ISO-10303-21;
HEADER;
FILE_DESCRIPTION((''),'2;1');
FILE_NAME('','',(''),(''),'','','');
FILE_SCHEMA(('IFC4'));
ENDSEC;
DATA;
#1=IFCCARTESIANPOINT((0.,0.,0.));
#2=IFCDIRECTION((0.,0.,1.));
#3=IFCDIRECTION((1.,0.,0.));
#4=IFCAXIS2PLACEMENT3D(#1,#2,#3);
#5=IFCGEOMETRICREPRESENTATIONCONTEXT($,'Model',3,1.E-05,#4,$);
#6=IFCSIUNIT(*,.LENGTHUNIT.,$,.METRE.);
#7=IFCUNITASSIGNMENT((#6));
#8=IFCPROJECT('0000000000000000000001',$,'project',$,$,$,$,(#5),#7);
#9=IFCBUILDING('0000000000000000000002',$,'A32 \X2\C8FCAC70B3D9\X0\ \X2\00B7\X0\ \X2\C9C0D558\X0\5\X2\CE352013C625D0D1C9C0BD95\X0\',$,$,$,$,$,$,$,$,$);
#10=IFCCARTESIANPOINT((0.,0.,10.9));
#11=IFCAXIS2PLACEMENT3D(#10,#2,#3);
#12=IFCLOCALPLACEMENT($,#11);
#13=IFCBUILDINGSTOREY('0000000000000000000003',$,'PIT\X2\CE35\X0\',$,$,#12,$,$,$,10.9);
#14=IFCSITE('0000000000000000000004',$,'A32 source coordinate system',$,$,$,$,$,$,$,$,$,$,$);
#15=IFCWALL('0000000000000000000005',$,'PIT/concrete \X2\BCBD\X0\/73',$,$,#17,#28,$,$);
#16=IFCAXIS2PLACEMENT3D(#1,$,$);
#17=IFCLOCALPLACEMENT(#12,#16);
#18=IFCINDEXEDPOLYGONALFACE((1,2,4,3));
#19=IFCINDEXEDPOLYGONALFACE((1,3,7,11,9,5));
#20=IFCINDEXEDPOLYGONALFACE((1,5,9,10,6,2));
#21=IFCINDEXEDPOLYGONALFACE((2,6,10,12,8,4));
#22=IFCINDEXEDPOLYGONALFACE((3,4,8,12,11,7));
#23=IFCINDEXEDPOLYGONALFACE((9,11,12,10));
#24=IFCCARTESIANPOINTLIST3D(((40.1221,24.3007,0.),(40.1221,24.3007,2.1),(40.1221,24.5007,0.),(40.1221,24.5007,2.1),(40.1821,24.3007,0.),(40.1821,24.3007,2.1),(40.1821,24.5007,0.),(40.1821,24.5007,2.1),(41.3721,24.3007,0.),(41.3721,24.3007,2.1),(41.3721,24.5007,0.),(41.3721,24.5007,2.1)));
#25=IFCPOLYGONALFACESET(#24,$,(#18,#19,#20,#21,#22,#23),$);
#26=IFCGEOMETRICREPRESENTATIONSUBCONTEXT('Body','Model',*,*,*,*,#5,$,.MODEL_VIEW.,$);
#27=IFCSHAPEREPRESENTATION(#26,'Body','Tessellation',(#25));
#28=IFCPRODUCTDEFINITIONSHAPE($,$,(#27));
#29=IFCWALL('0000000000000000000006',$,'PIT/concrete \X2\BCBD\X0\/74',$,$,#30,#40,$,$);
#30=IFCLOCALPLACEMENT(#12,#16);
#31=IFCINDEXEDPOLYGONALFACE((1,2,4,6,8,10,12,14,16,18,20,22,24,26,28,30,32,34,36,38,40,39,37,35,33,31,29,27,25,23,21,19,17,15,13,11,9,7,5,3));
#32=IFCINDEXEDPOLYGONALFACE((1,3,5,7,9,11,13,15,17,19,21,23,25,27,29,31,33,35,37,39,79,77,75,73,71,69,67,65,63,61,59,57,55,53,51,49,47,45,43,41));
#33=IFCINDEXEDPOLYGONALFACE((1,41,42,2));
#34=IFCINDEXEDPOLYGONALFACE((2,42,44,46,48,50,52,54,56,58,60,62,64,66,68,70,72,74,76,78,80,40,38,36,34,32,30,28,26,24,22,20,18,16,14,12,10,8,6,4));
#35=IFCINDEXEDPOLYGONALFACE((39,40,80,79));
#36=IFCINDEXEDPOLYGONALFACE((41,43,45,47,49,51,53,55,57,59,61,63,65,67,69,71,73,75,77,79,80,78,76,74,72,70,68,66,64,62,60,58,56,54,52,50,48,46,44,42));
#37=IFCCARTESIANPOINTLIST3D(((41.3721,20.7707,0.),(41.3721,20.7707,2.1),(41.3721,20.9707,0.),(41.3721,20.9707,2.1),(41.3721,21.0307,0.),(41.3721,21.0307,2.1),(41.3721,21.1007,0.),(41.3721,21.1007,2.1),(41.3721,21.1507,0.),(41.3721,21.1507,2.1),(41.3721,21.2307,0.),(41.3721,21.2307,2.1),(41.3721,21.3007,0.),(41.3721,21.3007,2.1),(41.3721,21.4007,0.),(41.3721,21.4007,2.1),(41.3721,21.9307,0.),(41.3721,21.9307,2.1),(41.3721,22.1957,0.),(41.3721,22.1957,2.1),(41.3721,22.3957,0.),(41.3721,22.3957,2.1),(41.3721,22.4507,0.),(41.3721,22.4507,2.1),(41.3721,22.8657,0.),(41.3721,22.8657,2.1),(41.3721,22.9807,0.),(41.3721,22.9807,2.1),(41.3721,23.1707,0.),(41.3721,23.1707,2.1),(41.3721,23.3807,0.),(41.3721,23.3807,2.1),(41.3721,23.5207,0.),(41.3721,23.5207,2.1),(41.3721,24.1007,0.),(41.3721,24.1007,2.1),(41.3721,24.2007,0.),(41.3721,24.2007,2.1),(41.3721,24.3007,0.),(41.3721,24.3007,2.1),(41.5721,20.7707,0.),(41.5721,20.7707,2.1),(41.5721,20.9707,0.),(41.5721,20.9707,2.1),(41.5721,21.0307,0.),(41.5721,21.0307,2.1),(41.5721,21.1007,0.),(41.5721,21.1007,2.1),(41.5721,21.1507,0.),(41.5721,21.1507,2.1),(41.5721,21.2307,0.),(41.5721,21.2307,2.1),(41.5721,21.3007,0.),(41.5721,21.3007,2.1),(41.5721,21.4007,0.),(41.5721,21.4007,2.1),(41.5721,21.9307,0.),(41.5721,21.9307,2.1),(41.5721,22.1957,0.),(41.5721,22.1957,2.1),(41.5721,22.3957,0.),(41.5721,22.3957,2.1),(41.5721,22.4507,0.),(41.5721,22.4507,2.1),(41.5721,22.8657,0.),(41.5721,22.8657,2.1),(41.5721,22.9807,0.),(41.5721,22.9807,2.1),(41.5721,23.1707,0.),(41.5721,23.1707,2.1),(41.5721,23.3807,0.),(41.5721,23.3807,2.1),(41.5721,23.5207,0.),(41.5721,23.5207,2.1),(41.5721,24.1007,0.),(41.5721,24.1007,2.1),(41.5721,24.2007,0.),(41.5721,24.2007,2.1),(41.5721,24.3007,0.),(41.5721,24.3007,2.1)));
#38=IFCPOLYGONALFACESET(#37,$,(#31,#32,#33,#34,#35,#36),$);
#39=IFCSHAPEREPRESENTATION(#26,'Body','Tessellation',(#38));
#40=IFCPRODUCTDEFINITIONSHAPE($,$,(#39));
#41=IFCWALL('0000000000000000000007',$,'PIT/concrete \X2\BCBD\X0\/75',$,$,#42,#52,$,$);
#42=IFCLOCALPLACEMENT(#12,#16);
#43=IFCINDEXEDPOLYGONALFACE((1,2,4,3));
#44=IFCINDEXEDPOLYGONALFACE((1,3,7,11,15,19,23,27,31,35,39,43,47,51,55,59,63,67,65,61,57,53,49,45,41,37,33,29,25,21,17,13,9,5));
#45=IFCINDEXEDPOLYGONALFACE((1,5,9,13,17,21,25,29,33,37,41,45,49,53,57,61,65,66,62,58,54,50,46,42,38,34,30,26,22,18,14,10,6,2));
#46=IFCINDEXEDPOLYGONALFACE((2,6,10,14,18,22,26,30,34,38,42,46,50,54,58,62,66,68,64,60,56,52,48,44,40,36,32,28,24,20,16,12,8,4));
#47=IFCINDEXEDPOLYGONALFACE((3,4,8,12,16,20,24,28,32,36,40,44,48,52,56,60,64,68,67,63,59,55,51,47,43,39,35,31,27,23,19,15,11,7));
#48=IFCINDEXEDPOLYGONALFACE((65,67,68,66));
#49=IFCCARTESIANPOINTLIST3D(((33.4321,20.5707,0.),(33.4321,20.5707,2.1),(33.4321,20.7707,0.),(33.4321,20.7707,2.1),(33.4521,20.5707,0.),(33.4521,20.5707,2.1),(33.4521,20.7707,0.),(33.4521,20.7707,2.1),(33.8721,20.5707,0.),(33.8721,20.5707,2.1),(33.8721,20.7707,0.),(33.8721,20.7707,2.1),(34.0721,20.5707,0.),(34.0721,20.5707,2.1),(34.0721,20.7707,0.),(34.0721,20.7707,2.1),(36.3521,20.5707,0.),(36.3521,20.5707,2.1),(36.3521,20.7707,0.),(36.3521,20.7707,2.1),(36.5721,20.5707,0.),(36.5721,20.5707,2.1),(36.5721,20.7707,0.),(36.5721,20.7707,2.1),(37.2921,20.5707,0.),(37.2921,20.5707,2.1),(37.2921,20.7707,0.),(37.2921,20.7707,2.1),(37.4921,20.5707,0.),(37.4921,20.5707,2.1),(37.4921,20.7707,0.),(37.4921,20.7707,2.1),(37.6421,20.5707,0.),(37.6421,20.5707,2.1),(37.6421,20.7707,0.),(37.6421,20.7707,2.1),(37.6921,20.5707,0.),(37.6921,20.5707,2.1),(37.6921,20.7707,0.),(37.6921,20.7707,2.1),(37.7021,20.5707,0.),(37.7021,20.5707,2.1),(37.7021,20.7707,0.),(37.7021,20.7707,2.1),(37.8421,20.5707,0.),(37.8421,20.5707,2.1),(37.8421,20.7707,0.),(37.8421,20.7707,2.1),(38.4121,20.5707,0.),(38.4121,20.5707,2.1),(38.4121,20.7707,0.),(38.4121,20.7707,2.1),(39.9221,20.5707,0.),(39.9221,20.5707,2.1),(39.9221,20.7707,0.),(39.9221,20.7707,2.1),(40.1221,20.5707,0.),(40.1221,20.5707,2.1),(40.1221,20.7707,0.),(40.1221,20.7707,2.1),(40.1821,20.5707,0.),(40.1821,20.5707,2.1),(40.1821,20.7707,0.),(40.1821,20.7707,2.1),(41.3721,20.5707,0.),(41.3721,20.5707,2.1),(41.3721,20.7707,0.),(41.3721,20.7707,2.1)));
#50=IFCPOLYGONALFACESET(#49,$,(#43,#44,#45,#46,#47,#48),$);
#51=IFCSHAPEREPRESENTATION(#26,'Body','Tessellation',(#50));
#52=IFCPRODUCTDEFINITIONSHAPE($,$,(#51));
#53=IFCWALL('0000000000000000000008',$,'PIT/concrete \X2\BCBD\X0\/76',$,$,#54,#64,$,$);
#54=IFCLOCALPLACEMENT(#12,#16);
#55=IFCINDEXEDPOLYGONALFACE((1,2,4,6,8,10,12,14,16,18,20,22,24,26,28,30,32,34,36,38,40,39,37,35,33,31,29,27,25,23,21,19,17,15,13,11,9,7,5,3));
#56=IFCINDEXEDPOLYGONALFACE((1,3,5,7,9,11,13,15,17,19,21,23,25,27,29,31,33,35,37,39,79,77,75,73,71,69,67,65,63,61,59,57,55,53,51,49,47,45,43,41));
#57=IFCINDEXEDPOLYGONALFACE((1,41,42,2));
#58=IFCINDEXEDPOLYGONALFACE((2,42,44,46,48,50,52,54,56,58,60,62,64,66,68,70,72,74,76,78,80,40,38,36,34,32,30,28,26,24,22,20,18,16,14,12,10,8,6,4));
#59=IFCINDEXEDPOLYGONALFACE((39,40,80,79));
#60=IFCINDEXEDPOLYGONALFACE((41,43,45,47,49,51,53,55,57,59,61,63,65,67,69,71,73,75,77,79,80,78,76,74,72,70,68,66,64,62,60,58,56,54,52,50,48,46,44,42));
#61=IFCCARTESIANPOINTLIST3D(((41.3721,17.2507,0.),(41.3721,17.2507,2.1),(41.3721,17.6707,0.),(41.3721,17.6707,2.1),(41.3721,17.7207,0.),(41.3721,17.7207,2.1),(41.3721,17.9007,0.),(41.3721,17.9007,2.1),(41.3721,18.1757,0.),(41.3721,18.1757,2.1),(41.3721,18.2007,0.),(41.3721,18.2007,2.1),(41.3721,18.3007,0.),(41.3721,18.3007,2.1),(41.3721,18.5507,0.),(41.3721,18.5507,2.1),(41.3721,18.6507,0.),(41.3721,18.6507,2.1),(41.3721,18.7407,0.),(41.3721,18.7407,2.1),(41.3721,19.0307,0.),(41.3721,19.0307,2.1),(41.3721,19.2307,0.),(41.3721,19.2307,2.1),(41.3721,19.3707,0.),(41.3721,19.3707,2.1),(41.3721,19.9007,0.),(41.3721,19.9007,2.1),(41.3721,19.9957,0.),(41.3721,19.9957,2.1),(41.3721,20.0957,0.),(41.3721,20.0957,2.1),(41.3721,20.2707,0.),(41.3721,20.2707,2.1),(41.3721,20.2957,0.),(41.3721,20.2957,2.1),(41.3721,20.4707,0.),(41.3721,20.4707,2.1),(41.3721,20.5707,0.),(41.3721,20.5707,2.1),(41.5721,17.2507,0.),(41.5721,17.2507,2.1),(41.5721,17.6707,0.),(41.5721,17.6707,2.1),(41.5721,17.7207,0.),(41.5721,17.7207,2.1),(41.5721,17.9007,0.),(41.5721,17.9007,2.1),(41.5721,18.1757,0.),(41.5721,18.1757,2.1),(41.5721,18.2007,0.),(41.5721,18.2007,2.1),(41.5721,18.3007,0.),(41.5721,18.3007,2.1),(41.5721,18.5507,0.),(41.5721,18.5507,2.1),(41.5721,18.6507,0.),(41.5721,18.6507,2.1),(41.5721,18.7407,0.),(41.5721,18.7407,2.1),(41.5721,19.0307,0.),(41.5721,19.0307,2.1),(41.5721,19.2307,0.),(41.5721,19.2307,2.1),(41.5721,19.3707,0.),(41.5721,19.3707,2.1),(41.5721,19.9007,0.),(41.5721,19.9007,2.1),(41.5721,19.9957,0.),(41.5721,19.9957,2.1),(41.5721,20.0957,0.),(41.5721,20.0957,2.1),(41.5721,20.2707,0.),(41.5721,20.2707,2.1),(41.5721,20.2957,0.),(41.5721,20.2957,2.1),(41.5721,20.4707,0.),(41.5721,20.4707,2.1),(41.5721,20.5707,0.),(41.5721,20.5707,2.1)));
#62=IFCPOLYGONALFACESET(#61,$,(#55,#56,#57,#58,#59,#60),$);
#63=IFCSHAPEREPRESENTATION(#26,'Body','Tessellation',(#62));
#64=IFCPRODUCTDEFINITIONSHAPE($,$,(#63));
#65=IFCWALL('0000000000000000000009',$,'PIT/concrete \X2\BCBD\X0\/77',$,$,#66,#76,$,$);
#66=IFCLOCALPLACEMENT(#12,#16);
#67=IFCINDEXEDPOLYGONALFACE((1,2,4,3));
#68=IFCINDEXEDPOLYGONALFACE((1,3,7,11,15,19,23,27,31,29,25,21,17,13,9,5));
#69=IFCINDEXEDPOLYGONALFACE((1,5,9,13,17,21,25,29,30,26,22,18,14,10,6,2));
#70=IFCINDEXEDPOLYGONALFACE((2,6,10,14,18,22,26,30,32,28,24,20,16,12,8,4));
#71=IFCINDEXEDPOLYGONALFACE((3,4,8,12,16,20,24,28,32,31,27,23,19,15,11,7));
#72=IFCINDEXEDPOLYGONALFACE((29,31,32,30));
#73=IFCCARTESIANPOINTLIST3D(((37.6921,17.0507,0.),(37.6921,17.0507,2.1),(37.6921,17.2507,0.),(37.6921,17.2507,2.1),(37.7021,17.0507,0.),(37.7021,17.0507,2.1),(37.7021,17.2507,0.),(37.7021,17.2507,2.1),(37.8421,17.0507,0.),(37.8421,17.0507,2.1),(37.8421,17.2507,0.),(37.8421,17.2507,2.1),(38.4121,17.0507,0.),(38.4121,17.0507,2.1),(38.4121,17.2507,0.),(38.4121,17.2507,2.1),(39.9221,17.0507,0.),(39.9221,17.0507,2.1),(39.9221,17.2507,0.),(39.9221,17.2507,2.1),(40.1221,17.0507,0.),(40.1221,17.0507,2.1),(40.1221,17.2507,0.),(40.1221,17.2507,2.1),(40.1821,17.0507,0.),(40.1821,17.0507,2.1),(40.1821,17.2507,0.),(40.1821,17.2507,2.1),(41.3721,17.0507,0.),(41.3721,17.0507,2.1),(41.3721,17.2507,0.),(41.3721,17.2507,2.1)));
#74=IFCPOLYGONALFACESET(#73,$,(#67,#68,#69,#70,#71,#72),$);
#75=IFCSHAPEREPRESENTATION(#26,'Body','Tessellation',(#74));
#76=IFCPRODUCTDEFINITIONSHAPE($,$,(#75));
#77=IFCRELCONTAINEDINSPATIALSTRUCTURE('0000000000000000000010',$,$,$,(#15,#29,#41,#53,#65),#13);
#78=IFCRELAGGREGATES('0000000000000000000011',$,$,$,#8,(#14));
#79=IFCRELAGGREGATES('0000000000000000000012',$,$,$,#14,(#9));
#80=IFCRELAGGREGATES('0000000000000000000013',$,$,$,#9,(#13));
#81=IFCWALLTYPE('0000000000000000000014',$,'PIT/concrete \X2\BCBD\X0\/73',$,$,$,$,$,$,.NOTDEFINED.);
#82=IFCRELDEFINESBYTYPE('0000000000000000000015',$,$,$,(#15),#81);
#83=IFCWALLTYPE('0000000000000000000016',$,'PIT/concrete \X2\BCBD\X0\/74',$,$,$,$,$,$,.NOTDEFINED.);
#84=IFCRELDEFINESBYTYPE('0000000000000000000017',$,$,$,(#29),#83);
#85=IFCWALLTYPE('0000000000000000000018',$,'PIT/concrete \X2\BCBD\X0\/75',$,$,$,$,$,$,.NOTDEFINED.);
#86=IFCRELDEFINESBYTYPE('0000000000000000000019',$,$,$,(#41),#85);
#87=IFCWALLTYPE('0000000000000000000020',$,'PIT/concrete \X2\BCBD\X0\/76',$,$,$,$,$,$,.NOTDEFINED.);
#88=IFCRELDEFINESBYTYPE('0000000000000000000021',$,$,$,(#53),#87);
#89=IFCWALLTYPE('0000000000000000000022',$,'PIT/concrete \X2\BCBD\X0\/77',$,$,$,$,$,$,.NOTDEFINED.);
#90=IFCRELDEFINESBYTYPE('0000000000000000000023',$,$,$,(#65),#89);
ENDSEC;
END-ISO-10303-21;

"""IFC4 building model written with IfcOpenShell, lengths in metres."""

from ifc_helpers import new_model, si_unit, frame, origin, origin_with_axes, place, context, subcontext, project, spatial, polyline, outline, extrude, source, transform, mapped, type_object, type_shapes, element, save


model = new_model("IFC4")

# Units and contexts
model_context = context("Model", 3, precision=1e-05, world=origin_with_axes())
body_context = subcontext(model_context, "Body", "Model", "MODEL_VIEW")
ifc_project = project(units=[si_unit("LENGTHUNIT", "METRE")], contexts=[model_context])

# Site, building, storey
site = spatial("IfcSite", under=ifc_project, Name="A32 source coordinate system")
building = spatial("IfcBuilding", under=site, Name="A32 주거동 · 지하5층–옥탑지붕")
storey_placement = place(None, frame((0.0, 0.0, 10.9), z_axis=(0.0, 0.0, 1.0), x_axis=(1.0, 0.0, 0.0)))
storey = spatial("IfcBuildingStorey", under=building, at=storey_placement, Name="PIT층", Elevation=10.9)

# Walls
wall_type_1 = type_object("IfcWallType", Name="PIT/concrete 벽/73", PredefinedType="NOTDEFINED")
shared_shape_1 = source(origin(), body_context, "Body", "SweptSolid", [
    extrude(outline(polyline([(40.1221, 24.3007), (40.1221, 24.5007), (40.1821, 24.5007), (41.3721, 24.5007), (41.3721, 24.3007), (40.1821, 24.3007), (40.1221, 24.3007)])), origin(), (0.0, 0.0, 1.0), 2.1),
])
type_shapes(wall_type_1, [shared_shape_1])
wall_1_placement = place(storey_placement, origin_with_axes())
element("IfcWall", 1, at=wall_1_placement, inside=storey, type_object=wall_type_1, Name="PIT/concrete 벽/73", context=body_context, shape_type="MappedRepresentation", body=[
    mapped(shared_shape_1, transform((0.0, 0.0, 0.0), scale=1.0)),
])
wall_type_2 = type_object("IfcWallType", Name="PIT/concrete 벽/74", PredefinedType="NOTDEFINED")
shared_shape_2 = source(origin(), body_context, "Body", "SweptSolid", [
    extrude(outline(polyline([(41.5721, 24.1007), (41.5721, 23.5207), (41.5721, 23.3807), (41.5721, 23.1707), (41.5721, 22.9807), (41.5721, 22.8657), (41.5721, 22.4507), (41.5721, 22.3957), (41.5721, 22.1957), (41.5721, 21.9307), (41.5721, 21.4007), (41.5721, 21.3007), (41.5721, 21.2307), (41.5721, 21.1507), (41.5721, 21.1007), (41.5721, 21.0307), (41.5721, 20.9707), (41.5721, 20.7707), (41.3721, 20.7707), (41.3721, 20.9707), (41.3721, 21.0307), (41.3721, 21.1007), (41.3721, 21.1507), (41.3721, 21.2307), (41.3721, 21.3007), (41.3721, 21.4007), (41.3721, 21.9307), (41.3721, 22.1957), (41.3721, 22.3957), (41.3721, 22.4507), (41.3721, 22.8657), (41.3721, 22.9807), (41.3721, 23.1707), (41.3721, 23.3807), (41.3721, 23.5207), (41.3721, 24.1007), (41.3721, 24.2007), (41.3721, 24.3007), (41.5721, 24.3007), (41.5721, 24.2007), (41.5721, 24.1007)])), origin(), (0.0, 0.0, 1.0), 2.1),
])
type_shapes(wall_type_2, [shared_shape_2])
wall_2_placement = place(storey_placement, origin_with_axes())
element("IfcWall", 2, at=wall_2_placement, inside=storey, type_object=wall_type_2, Name="PIT/concrete 벽/74", context=body_context, shape_type="MappedRepresentation", body=[
    mapped(shared_shape_2, transform((0.0, 0.0, 0.0), scale=1.0)),
])
wall_type_3 = type_object("IfcWallType", Name="PIT/concrete 벽/75", PredefinedType="NOTDEFINED")
shared_shape_3 = source(origin(), body_context, "Body", "SweptSolid", [
    extrude(outline(polyline([(40.1221, 20.5707), (39.9221, 20.5707), (38.4121, 20.5707), (37.8421, 20.5707), (37.7021, 20.5707), (37.6921, 20.5707), (37.6421, 20.5707), (37.4921, 20.5707), (37.2921, 20.5707), (36.5721, 20.5707), (36.3521, 20.5707), (34.0721, 20.5707), (33.8721, 20.5707), (33.4521, 20.5707), (33.4321, 20.5707), (33.4321, 20.7707), (33.4521, 20.7707), (33.8721, 20.7707), (34.0721, 20.7707), (36.3521, 20.7707), (36.5721, 20.7707), (37.2921, 20.7707), (37.4921, 20.7707), (37.6421, 20.7707), (37.6921, 20.7707), (37.7021, 20.7707), (37.8421, 20.7707), (38.4121, 20.7707), (39.9221, 20.7707), (40.1221, 20.7707), (40.1821, 20.7707), (41.3721, 20.7707), (41.3721, 20.5707), (40.1821, 20.5707), (40.1221, 20.5707)])), origin(), (0.0, 0.0, 1.0), 2.1),
])
type_shapes(wall_type_3, [shared_shape_3])
wall_3_placement = place(storey_placement, origin_with_axes())
element("IfcWall", 3, at=wall_3_placement, inside=storey, type_object=wall_type_3, Name="PIT/concrete 벽/75", context=body_context, shape_type="MappedRepresentation", body=[
    mapped(shared_shape_3, transform((0.0, 0.0, 0.0), scale=1.0)),
])
wall_type_4 = type_object("IfcWallType", Name="PIT/concrete 벽/76", PredefinedType="NOTDEFINED")
shared_shape_4 = source(origin(), body_context, "Body", "SweptSolid", [
    extrude(outline(polyline([(41.5721, 20.2957), (41.5721, 20.2707), (41.5721, 20.0957), (41.5721, 19.9957), (41.5721, 19.9007), (41.5721, 19.3707), (41.5721, 19.2307), (41.5721, 19.0307), (41.5721, 18.7407), (41.5721, 18.6507), (41.5721, 18.5507), (41.5721, 18.3007), (41.5721, 18.2007), (41.5721, 18.1757), (41.5721, 17.9007), (41.5721, 17.7207), (41.5721, 17.6707), (41.5721, 17.2507), (41.3721, 17.2507), (41.3721, 17.6707), (41.3721, 17.7207), (41.3721, 17.9007), (41.3721, 18.1757), (41.3721, 18.2007), (41.3721, 18.3007), (41.3721, 18.5507), (41.3721, 18.6507), (41.3721, 18.7407), (41.3721, 19.0307), (41.3721, 19.2307), (41.3721, 19.3707), (41.3721, 19.9007), (41.3721, 19.9957), (41.3721, 20.0957), (41.3721, 20.2707), (41.3721, 20.2957), (41.3721, 20.4707), (41.3721, 20.5707), (41.5721, 20.5707), (41.5721, 20.4707), (41.5721, 20.2957)])), origin(), (0.0, 0.0, 1.0), 2.1),
])
type_shapes(wall_type_4, [shared_shape_4])
wall_4_placement = place(storey_placement, origin_with_axes())
element("IfcWall", 4, at=wall_4_placement, inside=storey, type_object=wall_type_4, Name="PIT/concrete 벽/76", context=body_context, shape_type="MappedRepresentation", body=[
    mapped(shared_shape_4, transform((0.0, 0.0, 0.0), scale=1.0)),
])
wall_type_5 = type_object("IfcWallType", Name="PIT/concrete 벽/77", PredefinedType="NOTDEFINED")
shared_shape_5 = source(origin(), body_context, "Body", "SweptSolid", [
    extrude(outline(polyline([(40.1221, 17.0507), (39.9221, 17.0507), (38.4121, 17.0507), (37.8421, 17.0507), (37.7021, 17.0507), (37.6921, 17.0507), (37.6921, 17.2507), (37.7021, 17.2507), (37.8421, 17.2507), (38.4121, 17.2507), (39.9221, 17.2507), (40.1221, 17.2507), (40.1821, 17.2507), (41.3721, 17.2507), (41.3721, 17.0507), (40.1821, 17.0507), (40.1221, 17.0507)])), origin(), (0.0, 0.0, 1.0), 2.1),
])
type_shapes(wall_type_5, [shared_shape_5])
wall_5_placement = place(storey_placement, origin_with_axes())
element("IfcWall", 5, at=wall_5_placement, inside=storey, type_object=wall_type_5, Name="PIT/concrete 벽/77", context=body_context, shape_type="MappedRepresentation", body=[
    mapped(shared_shape_5, transform((0.0, 0.0, 0.0), scale=1.0)),
])

save(model, "model.ifc")
